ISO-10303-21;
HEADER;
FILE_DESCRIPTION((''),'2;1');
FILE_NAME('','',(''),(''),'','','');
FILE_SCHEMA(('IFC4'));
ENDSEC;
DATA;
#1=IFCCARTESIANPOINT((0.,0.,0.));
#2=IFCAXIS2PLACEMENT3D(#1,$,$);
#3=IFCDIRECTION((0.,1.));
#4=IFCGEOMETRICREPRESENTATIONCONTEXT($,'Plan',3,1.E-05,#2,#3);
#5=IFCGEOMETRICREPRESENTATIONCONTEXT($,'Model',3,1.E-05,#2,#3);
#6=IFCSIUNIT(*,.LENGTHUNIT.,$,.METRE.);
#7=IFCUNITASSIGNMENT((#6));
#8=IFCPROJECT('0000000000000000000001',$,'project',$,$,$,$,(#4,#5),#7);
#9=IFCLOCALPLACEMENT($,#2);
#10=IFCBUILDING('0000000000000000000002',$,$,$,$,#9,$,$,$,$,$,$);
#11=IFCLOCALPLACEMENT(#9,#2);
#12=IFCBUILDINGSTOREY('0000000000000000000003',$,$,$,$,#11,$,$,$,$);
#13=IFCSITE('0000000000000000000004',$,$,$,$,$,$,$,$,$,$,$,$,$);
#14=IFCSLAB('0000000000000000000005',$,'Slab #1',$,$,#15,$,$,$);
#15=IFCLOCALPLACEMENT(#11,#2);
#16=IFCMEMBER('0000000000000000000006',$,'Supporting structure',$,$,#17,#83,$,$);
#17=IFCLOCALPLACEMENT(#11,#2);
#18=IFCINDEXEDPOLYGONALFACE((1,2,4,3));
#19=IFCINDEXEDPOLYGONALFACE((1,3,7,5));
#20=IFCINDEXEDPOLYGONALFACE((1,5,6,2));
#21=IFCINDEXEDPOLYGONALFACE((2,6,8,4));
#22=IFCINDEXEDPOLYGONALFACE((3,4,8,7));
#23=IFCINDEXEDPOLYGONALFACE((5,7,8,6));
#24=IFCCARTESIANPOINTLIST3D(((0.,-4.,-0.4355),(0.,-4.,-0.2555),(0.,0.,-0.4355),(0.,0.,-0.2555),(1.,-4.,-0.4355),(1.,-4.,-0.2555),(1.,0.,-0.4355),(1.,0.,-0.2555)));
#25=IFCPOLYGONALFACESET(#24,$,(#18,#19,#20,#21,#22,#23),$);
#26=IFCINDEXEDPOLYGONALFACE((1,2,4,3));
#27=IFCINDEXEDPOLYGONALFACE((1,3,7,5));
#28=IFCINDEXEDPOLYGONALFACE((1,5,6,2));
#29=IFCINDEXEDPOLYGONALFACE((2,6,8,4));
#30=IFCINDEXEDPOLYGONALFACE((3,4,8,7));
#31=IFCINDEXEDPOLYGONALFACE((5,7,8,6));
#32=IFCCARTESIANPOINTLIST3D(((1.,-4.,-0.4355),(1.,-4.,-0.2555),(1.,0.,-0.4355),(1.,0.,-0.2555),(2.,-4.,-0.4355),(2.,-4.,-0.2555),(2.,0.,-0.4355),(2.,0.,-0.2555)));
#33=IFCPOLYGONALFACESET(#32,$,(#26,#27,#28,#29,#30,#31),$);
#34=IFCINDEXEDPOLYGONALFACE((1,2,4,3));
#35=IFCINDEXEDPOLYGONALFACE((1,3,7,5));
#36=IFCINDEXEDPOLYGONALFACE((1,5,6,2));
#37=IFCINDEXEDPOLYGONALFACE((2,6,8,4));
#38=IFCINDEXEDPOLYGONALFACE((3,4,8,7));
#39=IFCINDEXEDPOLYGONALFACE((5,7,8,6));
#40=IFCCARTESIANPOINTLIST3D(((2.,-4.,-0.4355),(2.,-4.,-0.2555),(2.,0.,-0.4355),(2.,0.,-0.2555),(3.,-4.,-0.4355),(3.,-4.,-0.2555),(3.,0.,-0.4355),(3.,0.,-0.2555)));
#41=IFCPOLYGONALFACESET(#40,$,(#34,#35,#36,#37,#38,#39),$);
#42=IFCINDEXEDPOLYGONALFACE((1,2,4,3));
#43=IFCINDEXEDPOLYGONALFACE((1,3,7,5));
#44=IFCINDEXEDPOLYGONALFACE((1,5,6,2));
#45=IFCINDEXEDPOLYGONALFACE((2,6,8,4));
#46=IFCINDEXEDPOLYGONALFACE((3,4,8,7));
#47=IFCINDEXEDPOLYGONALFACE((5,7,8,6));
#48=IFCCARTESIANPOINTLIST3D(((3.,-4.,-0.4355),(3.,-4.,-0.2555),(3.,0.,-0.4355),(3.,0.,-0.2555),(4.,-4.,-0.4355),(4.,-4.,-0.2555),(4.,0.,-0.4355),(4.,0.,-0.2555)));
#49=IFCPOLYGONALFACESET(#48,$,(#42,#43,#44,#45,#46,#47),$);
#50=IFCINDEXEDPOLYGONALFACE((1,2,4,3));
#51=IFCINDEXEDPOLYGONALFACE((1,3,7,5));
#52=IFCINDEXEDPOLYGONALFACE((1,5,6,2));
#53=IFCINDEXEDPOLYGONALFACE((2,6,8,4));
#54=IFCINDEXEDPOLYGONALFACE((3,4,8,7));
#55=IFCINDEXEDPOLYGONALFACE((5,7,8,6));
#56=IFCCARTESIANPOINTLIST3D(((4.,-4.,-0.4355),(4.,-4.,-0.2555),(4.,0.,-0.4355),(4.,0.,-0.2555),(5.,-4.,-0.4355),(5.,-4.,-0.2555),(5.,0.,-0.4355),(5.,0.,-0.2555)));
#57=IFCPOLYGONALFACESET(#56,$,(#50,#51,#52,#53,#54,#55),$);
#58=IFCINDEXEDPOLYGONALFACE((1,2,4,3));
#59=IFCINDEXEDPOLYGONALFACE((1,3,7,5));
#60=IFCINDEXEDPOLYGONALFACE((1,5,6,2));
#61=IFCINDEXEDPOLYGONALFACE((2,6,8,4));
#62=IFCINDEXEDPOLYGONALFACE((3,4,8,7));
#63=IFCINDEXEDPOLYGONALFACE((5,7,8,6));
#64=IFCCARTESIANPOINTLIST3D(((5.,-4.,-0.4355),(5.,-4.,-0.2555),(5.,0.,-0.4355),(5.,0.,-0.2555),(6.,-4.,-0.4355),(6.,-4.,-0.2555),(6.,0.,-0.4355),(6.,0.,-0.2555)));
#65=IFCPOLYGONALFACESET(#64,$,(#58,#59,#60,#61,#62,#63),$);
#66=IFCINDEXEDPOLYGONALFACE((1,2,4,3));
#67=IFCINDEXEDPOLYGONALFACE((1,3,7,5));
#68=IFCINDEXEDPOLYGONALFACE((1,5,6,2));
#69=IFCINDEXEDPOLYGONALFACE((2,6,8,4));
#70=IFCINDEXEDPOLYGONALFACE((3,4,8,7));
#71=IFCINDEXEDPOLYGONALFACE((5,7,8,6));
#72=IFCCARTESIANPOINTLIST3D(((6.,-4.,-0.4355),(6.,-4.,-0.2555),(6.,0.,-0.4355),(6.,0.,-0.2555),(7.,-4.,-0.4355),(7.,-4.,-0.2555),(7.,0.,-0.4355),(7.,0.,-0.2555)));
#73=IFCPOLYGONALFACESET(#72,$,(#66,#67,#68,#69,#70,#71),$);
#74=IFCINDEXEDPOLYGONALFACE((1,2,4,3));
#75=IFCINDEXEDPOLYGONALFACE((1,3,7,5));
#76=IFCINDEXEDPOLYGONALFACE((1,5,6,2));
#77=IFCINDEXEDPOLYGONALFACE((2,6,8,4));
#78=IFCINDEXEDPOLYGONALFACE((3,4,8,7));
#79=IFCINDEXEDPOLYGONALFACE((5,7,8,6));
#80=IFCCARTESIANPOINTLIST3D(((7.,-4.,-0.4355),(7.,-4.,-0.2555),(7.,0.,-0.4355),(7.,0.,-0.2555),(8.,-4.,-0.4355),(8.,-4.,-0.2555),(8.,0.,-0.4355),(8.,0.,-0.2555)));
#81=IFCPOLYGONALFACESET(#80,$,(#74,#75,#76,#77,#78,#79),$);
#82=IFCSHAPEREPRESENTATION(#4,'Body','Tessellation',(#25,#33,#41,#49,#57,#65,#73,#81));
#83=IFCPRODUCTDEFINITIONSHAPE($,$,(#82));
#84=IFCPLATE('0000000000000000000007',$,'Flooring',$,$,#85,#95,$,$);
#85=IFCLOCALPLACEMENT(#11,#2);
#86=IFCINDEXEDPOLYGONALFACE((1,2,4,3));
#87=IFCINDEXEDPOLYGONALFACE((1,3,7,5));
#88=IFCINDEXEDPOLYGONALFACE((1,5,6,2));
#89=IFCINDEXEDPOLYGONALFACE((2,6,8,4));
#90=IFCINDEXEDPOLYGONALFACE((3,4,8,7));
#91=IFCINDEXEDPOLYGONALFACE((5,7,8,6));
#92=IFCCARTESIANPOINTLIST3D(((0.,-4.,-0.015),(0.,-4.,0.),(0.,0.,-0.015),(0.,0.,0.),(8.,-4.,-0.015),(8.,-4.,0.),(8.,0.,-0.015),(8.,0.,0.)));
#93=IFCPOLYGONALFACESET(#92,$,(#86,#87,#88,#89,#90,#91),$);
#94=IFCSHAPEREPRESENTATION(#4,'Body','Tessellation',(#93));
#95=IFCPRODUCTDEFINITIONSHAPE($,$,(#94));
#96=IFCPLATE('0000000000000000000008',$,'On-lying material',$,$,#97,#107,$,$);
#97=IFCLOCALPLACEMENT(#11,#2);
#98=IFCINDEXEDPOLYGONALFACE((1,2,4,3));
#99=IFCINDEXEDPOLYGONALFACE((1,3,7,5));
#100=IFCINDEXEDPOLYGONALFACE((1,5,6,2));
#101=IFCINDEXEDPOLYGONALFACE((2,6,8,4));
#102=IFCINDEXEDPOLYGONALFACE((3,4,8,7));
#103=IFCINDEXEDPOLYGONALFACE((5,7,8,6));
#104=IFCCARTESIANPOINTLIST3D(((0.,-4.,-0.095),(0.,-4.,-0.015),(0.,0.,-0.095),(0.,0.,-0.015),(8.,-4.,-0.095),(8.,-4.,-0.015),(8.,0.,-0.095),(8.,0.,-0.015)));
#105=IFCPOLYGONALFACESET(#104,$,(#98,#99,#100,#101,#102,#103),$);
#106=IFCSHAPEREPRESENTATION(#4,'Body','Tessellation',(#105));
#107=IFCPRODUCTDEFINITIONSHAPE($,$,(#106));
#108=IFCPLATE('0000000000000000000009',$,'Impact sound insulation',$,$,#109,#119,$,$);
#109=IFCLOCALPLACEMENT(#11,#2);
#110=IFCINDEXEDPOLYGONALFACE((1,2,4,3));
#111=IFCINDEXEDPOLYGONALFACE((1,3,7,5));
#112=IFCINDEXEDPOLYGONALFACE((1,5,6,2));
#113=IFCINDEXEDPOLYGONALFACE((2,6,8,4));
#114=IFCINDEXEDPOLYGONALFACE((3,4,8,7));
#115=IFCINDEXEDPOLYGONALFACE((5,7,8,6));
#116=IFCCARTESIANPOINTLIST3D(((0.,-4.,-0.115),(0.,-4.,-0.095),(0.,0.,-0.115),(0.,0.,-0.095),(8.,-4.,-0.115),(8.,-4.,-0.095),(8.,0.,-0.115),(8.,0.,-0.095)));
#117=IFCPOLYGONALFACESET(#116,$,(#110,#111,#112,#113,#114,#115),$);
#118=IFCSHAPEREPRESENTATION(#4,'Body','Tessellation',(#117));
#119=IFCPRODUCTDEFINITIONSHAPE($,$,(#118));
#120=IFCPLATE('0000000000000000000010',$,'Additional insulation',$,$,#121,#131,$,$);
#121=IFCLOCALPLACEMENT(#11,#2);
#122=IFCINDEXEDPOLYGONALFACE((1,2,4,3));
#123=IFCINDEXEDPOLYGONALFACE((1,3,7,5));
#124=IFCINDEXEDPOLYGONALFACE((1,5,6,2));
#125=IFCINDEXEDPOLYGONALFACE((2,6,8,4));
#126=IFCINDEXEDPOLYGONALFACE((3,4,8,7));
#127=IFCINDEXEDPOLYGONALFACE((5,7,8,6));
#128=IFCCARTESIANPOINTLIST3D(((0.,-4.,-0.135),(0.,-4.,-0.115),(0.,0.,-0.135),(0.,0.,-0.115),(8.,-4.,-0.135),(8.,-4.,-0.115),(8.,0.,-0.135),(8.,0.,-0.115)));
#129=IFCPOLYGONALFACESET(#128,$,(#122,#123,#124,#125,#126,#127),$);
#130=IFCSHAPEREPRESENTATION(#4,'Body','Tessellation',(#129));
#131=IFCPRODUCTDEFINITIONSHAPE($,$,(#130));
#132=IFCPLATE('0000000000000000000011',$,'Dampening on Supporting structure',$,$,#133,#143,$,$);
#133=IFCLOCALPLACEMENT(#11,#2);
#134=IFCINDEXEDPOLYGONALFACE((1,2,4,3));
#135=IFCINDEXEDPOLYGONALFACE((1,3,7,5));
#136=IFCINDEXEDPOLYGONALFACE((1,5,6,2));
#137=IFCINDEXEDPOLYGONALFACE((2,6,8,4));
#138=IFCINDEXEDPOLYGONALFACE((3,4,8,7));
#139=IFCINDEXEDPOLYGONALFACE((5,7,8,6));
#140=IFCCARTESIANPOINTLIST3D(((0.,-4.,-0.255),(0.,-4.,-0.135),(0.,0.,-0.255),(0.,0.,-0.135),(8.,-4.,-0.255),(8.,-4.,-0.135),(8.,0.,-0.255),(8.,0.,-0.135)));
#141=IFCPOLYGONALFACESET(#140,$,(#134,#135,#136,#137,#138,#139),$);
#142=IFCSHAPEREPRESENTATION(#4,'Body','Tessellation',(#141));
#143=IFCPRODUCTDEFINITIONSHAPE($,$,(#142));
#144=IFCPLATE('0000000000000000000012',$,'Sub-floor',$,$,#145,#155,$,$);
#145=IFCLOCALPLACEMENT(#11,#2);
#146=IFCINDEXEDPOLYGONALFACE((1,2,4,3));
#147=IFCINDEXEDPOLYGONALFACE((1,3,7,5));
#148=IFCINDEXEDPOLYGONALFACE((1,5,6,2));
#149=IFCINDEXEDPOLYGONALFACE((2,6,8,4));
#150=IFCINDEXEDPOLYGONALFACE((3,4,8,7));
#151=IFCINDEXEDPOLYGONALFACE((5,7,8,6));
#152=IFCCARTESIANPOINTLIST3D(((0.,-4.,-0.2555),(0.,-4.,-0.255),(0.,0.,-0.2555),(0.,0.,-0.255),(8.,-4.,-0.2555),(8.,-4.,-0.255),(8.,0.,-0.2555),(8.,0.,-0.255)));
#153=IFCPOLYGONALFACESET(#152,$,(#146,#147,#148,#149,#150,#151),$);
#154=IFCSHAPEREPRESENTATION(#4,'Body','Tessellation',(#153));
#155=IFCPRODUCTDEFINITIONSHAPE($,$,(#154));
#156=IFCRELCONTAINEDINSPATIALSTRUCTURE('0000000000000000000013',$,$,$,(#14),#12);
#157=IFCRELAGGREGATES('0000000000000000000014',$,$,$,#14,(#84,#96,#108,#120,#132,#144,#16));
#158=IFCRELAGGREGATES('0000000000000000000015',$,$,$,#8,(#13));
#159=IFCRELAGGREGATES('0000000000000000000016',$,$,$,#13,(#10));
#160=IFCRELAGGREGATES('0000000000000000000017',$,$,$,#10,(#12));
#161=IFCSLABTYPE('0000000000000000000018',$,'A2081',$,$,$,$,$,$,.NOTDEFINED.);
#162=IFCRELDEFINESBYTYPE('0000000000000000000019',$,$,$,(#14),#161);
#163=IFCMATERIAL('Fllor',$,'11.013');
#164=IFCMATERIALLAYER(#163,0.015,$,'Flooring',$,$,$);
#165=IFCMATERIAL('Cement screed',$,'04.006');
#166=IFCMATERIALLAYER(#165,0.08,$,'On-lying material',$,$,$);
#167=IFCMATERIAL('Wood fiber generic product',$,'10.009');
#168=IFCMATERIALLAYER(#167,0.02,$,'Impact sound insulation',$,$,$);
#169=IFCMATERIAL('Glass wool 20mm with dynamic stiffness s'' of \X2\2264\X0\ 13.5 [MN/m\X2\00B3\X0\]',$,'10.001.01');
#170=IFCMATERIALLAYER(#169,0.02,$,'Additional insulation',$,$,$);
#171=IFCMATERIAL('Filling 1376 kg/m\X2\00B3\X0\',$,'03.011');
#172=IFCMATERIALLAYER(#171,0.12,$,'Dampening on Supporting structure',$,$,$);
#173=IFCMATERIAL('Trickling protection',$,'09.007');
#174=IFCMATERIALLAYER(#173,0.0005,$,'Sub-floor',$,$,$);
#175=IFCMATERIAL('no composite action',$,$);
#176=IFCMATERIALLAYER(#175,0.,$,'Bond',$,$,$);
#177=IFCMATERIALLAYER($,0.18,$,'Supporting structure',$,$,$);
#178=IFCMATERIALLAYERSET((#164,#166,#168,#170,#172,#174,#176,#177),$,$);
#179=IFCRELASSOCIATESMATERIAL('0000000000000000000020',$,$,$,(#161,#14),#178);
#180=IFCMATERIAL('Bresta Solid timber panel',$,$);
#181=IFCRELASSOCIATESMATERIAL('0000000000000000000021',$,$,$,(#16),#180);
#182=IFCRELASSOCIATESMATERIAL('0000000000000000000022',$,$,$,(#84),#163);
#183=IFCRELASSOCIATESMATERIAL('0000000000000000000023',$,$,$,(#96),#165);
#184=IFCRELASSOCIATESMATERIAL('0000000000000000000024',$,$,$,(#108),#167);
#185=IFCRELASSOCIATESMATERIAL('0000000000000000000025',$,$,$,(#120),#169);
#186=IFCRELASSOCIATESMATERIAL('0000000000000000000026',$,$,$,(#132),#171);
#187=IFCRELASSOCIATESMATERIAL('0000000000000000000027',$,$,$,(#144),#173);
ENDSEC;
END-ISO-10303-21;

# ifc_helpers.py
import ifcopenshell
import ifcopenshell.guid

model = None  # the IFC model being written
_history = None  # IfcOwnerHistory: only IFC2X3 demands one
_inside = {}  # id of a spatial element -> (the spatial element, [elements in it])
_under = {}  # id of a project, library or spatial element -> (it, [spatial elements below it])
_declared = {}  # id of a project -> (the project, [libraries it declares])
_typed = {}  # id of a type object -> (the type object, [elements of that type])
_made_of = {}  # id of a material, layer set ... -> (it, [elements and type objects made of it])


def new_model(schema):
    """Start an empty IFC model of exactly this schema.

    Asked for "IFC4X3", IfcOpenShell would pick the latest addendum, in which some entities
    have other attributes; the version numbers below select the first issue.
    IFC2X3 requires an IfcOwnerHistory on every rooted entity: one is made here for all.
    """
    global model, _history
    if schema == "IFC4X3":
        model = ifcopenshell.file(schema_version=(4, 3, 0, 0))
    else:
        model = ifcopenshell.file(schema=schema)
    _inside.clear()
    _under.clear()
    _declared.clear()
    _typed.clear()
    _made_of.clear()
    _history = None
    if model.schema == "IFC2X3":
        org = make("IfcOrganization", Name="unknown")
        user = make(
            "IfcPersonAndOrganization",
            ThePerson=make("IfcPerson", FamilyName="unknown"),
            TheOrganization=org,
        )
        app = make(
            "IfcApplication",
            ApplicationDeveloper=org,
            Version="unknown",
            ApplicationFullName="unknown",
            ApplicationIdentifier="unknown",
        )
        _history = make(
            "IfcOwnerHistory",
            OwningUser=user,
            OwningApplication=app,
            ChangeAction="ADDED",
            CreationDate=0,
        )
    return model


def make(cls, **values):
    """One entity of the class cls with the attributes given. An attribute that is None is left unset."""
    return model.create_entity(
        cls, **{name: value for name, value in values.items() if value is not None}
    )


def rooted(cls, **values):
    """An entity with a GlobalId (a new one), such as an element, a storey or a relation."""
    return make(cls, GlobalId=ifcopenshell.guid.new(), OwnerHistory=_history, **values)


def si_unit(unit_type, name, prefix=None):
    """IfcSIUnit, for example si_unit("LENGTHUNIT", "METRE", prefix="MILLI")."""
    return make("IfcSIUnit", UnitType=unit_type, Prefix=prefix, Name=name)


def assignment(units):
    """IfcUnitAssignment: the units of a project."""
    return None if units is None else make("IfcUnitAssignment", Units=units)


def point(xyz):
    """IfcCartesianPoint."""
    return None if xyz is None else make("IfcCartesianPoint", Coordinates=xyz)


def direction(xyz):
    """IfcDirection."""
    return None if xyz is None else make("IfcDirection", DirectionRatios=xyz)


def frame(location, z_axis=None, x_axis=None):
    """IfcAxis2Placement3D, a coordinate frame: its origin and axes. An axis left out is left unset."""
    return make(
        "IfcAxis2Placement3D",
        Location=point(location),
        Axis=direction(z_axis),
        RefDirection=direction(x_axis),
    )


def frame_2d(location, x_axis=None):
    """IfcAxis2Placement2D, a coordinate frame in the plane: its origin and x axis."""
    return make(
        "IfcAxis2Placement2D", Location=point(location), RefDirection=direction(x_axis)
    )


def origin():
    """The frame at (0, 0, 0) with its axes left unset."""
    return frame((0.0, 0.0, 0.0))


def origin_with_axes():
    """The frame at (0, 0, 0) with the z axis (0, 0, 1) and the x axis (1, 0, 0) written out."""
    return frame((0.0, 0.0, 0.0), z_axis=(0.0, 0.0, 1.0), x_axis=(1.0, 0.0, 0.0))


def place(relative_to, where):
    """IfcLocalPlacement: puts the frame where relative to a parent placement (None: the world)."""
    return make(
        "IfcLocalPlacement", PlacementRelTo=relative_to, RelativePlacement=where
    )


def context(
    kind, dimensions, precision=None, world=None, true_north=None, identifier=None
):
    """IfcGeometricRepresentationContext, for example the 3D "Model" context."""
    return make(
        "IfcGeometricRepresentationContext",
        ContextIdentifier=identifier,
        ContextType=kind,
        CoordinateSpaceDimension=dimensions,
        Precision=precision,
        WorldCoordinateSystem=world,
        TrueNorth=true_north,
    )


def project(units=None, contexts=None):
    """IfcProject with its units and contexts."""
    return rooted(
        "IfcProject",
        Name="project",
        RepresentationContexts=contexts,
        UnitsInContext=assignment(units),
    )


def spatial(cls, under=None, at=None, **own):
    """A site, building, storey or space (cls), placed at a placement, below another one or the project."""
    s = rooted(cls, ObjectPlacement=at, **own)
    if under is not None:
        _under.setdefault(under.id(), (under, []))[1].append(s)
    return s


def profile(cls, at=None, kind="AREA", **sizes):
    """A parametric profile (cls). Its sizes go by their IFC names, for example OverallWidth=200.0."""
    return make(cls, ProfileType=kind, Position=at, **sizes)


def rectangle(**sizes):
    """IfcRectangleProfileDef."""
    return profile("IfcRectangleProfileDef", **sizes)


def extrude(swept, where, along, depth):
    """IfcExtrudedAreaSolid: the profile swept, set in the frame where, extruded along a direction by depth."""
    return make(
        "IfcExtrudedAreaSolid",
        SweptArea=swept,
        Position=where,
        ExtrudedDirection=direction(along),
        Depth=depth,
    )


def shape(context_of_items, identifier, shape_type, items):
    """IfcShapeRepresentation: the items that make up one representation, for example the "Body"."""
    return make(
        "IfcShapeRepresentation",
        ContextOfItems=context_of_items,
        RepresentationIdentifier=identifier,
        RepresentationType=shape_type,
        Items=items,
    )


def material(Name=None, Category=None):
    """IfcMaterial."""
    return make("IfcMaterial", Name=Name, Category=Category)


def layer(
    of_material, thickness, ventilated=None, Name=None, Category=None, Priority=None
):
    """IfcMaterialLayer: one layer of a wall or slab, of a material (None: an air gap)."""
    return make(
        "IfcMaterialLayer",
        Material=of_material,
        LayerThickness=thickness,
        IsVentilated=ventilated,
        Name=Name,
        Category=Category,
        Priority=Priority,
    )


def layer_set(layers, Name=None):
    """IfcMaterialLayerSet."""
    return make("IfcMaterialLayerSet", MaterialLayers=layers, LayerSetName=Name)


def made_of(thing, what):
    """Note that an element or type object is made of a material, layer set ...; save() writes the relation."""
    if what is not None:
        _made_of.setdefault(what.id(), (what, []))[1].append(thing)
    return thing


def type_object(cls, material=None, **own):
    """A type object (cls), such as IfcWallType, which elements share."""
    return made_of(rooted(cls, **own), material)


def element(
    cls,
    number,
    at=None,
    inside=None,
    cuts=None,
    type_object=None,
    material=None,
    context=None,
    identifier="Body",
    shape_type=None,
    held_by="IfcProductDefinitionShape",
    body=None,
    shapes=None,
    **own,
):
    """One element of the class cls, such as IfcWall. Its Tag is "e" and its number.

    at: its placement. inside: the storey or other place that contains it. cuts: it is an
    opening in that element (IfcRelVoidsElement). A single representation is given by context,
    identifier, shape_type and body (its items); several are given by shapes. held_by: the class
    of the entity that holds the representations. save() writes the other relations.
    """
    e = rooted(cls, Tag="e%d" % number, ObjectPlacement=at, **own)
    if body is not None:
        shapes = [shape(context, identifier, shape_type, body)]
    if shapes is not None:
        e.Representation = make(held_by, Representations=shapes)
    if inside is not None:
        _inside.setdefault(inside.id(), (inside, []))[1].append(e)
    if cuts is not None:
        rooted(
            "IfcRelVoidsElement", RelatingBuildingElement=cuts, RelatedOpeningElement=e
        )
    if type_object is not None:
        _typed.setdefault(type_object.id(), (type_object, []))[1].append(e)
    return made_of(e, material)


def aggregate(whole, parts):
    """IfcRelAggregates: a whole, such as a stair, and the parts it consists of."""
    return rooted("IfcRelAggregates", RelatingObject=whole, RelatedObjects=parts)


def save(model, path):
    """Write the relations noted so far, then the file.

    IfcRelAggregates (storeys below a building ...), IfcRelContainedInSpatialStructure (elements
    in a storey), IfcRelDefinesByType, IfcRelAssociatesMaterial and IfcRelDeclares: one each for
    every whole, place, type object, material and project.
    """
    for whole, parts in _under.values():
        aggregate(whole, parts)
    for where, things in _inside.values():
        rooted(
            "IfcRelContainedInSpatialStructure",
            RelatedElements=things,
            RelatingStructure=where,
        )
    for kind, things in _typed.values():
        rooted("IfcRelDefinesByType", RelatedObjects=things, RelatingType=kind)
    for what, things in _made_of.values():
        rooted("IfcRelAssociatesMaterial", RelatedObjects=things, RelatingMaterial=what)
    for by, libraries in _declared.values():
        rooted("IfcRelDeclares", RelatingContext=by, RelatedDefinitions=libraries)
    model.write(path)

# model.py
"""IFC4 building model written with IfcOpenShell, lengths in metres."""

from ifc_helpers import new_model, si_unit, direction, frame, frame_2d, origin, origin_with_axes, place, context, project, spatial, rectangle, extrude, material, layer, layer_set, type_object, element, aggregate, save


model = new_model("IFC4")

# Units and contexts
plan_context = context("Plan", 3, precision=1e-05, world=origin(), true_north=direction((0.0, 1.0)))
model_context = context("Model", 3, precision=1e-05, world=origin(), true_north=direction((0.0, 1.0)))
ifc_project = project(units=[si_unit("LENGTHUNIT", "METRE")], contexts=[plan_context, model_context])

# Site, building, storey
site = spatial("IfcSite", under=ifc_project)
building_placement = place(None, origin())
building = spatial("IfcBuilding", under=site, at=building_placement)
storey_placement = place(building_placement, origin())
storey = spatial("IfcBuildingStorey", under=building, at=storey_placement)

# Slab, member, plates
ifc_material_1 = material(Name="Fllor", Category="11.013")
ifc_layer_1 = layer(ifc_material_1, 0.015, Name="Flooring")
ifc_material_2 = material(Name="Cement screed", Category="04.006")
ifc_layer_2 = layer(ifc_material_2, 0.08, Name="On-lying material")
ifc_material_3 = material(Name="Wood fiber generic product", Category="10.009")
ifc_layer_3 = layer(ifc_material_3, 0.02, Name="Impact sound insulation")
ifc_material_4 = material(Name="Glass wool 20mm with dynamic stiffness s' of ≤ 13.5 [MN/m³]", Category="10.001.01")
ifc_layer_4 = layer(ifc_material_4, 0.02, Name="Additional insulation")
ifc_material_5 = material(Name="Filling 1376 kg/m³", Category="03.011")
ifc_layer_5 = layer(ifc_material_5, 0.12, Name="Dampening on Supporting structure")
ifc_material_6 = material(Name="Trickling protection", Category="09.007")
ifc_layer_6 = layer(ifc_material_6, 0.0005, Name="Sub-floor")
ifc_material_7 = material(Name="no composite action")
ifc_layer_7 = layer(ifc_material_7, 0.0, Name="Bond")
ifc_layer_8 = layer(None, 0.18, Name="Supporting structure")
ifc_layer_set = layer_set([ifc_layer_1, ifc_layer_2, ifc_layer_3, ifc_layer_4, ifc_layer_5, ifc_layer_6, ifc_layer_7, ifc_layer_8])
slab_type = type_object("IfcSlabType", Name="A2081", PredefinedType="NOTDEFINED", material=ifc_layer_set)
slab_placement = place(None, frame((0.0, 0.0, 0.0), z_axis=(0.0, 0.0, -1.0), x_axis=(1.0, 0.0, 0.0)))
slab = element("IfcSlab", 1, at=slab_placement, inside=storey, type_object=slab_type, material=ifc_layer_set, Name="Slab #1")
ifc_material_8 = material(Name="Bresta Solid timber panel")
member_placement = place(slab_placement, origin())
member = element("IfcMember", 2, at=member_placement, material=ifc_material_8, Name="Supporting structure", context=plan_context, shape_type="SweptSolid", body=[
    extrude(rectangle(XDim=1.0, YDim=0.18, at=frame_2d((0.5, 0.09), x_axis=(1.0, 0.0))), frame((0.0, 4.0, 0.2555), z_axis=(0.0, -1.0, 0.0), x_axis=(1.0, 0.0, 0.0)), (0.0, 0.0, 1.0), 4.0),
    extrude(rectangle(XDim=1.0, YDim=0.18, at=frame_2d((0.5, 0.09), x_axis=(1.0, 0.0))), frame((1.0, 4.0, 0.2555), z_axis=(0.0, -1.0, 0.0), x_axis=(1.0, 0.0, 0.0)), (0.0, 0.0, 1.0), 4.0),
    extrude(rectangle(XDim=1.0, YDim=0.18, at=frame_2d((0.5, 0.09), x_axis=(1.0, 0.0))), frame((2.0, 4.0, 0.2555), z_axis=(0.0, -1.0, 0.0), x_axis=(1.0, 0.0, 0.0)), (0.0, 0.0, 1.0), 4.0),
    extrude(rectangle(XDim=1.0, YDim=0.18, at=frame_2d((0.5, 0.09), x_axis=(1.0, 0.0))), frame((3.0, 4.0, 0.2555), z_axis=(0.0, -1.0, 0.0), x_axis=(1.0, 0.0, 0.0)), (0.0, 0.0, 1.0), 4.0),
    extrude(rectangle(XDim=1.0, YDim=0.18, at=frame_2d((0.5, 0.09), x_axis=(1.0, 0.0))), frame((4.0, 4.0, 0.2555), z_axis=(0.0, -1.0, 0.0), x_axis=(1.0, 0.0, 0.0)), (0.0, 0.0, 1.0), 4.0),
    extrude(rectangle(XDim=1.0, YDim=0.18, at=frame_2d((0.5, 0.09), x_axis=(1.0, 0.0))), frame((5.0, 4.0, 0.2555), z_axis=(0.0, -1.0, 0.0), x_axis=(1.0, 0.0, 0.0)), (0.0, 0.0, 1.0), 4.0),
    extrude(rectangle(XDim=1.0, YDim=0.18, at=frame_2d((0.5, 0.09), x_axis=(1.0, 0.0))), frame((6.0, 4.0, 0.2555), z_axis=(0.0, -1.0, 0.0), x_axis=(1.0, 0.0, 0.0)), (0.0, 0.0, 1.0), 4.0),
    extrude(rectangle(XDim=1.0, YDim=0.18, at=frame_2d((0.5, 0.09), x_axis=(1.0, 0.0))), frame((7.0, 4.0, 0.2555), z_axis=(0.0, -1.0, 0.0), x_axis=(1.0, 0.0, 0.0)), (0.0, 0.0, 1.0), 4.0),
])
plate_1_placement = place(slab_placement, origin())
plate_1 = element("IfcPlate", 3, at=plate_1_placement, material=ifc_material_1, Name="Flooring", context=plan_context, shape_type="SweptSolid", body=[
    extrude(rectangle(XDim=8.0, YDim=4.0, at=frame_2d((4.0, 2.0), x_axis=(1.0, 0.0))), origin_with_axes(), (0.0, 0.0, 1.0), 0.015),
])
plate_2_placement = place(slab_placement, origin())
plate_2 = element("IfcPlate", 4, at=plate_2_placement, material=ifc_material_2, Name="On-lying material", context=plan_context, shape_type="SweptSolid", body=[
    extrude(rectangle(XDim=8.0, YDim=4.0, at=frame_2d((4.0, 2.0), x_axis=(1.0, 0.0))), frame((0.0, 0.0, 0.015), z_axis=(0.0, 0.0, 1.0), x_axis=(1.0, 0.0, 0.0)), (0.0, 0.0, 1.0), 0.08),
])
plate_3_placement = place(slab_placement, origin())
plate_3 = element("IfcPlate", 5, at=plate_3_placement, material=ifc_material_3, Name="Impact sound insulation", context=plan_context, shape_type="SweptSolid", body=[
    extrude(rectangle(XDim=8.0, YDim=4.0, at=frame_2d((4.0, 2.0), x_axis=(1.0, 0.0))), frame((0.0, 0.0, 0.095), z_axis=(0.0, 0.0, 1.0), x_axis=(1.0, 0.0, 0.0)), (0.0, 0.0, 1.0), 0.02),
])
plate_4_placement = place(slab_placement, origin())
plate_4 = element("IfcPlate", 6, at=plate_4_placement, material=ifc_material_4, Name="Additional insulation", context=plan_context, shape_type="SweptSolid", body=[
    extrude(rectangle(XDim=8.0, YDim=4.0, at=frame_2d((4.0, 2.0), x_axis=(1.0, 0.0))), frame((0.0, 0.0, 0.115), z_axis=(0.0, 0.0, 1.0), x_axis=(1.0, 0.0, 0.0)), (0.0, 0.0, 1.0), 0.02),
])
plate_5_placement = place(slab_placement, origin())
plate_5 = element("IfcPlate", 7, at=plate_5_placement, material=ifc_material_5, Name="Dampening on Supporting structure", context=plan_context, shape_type="SweptSolid", body=[
    extrude(rectangle(XDim=8.0, YDim=4.0, at=frame_2d((4.0, 2.0), x_axis=(1.0, 0.0))), frame((0.0, 0.0, 0.135), z_axis=(0.0, 0.0, 1.0), x_axis=(1.0, 0.0, 0.0)), (0.0, 0.0, 1.0), 0.12),
])
plate_6_placement = place(slab_placement, origin())
plate_6 = element("IfcPlate", 8, at=plate_6_placement, material=ifc_material_6, Name="Sub-floor", context=plan_context, shape_type="SweptSolid", body=[
    extrude(rectangle(XDim=8.0, YDim=4.0, at=frame_2d((4.0, 2.0), x_axis=(1.0, 0.0))), frame((0.0, 0.0, 0.255), z_axis=(0.0, 0.0, 1.0), x_axis=(1.0, 0.0, 0.0)), (0.0, 0.0, 1.0), 0.0005),
])
aggregate(slab, [plate_1, plate_2, plate_3, plate_4, plate_5, plate_6, member])

save(model, "model.ifc")
